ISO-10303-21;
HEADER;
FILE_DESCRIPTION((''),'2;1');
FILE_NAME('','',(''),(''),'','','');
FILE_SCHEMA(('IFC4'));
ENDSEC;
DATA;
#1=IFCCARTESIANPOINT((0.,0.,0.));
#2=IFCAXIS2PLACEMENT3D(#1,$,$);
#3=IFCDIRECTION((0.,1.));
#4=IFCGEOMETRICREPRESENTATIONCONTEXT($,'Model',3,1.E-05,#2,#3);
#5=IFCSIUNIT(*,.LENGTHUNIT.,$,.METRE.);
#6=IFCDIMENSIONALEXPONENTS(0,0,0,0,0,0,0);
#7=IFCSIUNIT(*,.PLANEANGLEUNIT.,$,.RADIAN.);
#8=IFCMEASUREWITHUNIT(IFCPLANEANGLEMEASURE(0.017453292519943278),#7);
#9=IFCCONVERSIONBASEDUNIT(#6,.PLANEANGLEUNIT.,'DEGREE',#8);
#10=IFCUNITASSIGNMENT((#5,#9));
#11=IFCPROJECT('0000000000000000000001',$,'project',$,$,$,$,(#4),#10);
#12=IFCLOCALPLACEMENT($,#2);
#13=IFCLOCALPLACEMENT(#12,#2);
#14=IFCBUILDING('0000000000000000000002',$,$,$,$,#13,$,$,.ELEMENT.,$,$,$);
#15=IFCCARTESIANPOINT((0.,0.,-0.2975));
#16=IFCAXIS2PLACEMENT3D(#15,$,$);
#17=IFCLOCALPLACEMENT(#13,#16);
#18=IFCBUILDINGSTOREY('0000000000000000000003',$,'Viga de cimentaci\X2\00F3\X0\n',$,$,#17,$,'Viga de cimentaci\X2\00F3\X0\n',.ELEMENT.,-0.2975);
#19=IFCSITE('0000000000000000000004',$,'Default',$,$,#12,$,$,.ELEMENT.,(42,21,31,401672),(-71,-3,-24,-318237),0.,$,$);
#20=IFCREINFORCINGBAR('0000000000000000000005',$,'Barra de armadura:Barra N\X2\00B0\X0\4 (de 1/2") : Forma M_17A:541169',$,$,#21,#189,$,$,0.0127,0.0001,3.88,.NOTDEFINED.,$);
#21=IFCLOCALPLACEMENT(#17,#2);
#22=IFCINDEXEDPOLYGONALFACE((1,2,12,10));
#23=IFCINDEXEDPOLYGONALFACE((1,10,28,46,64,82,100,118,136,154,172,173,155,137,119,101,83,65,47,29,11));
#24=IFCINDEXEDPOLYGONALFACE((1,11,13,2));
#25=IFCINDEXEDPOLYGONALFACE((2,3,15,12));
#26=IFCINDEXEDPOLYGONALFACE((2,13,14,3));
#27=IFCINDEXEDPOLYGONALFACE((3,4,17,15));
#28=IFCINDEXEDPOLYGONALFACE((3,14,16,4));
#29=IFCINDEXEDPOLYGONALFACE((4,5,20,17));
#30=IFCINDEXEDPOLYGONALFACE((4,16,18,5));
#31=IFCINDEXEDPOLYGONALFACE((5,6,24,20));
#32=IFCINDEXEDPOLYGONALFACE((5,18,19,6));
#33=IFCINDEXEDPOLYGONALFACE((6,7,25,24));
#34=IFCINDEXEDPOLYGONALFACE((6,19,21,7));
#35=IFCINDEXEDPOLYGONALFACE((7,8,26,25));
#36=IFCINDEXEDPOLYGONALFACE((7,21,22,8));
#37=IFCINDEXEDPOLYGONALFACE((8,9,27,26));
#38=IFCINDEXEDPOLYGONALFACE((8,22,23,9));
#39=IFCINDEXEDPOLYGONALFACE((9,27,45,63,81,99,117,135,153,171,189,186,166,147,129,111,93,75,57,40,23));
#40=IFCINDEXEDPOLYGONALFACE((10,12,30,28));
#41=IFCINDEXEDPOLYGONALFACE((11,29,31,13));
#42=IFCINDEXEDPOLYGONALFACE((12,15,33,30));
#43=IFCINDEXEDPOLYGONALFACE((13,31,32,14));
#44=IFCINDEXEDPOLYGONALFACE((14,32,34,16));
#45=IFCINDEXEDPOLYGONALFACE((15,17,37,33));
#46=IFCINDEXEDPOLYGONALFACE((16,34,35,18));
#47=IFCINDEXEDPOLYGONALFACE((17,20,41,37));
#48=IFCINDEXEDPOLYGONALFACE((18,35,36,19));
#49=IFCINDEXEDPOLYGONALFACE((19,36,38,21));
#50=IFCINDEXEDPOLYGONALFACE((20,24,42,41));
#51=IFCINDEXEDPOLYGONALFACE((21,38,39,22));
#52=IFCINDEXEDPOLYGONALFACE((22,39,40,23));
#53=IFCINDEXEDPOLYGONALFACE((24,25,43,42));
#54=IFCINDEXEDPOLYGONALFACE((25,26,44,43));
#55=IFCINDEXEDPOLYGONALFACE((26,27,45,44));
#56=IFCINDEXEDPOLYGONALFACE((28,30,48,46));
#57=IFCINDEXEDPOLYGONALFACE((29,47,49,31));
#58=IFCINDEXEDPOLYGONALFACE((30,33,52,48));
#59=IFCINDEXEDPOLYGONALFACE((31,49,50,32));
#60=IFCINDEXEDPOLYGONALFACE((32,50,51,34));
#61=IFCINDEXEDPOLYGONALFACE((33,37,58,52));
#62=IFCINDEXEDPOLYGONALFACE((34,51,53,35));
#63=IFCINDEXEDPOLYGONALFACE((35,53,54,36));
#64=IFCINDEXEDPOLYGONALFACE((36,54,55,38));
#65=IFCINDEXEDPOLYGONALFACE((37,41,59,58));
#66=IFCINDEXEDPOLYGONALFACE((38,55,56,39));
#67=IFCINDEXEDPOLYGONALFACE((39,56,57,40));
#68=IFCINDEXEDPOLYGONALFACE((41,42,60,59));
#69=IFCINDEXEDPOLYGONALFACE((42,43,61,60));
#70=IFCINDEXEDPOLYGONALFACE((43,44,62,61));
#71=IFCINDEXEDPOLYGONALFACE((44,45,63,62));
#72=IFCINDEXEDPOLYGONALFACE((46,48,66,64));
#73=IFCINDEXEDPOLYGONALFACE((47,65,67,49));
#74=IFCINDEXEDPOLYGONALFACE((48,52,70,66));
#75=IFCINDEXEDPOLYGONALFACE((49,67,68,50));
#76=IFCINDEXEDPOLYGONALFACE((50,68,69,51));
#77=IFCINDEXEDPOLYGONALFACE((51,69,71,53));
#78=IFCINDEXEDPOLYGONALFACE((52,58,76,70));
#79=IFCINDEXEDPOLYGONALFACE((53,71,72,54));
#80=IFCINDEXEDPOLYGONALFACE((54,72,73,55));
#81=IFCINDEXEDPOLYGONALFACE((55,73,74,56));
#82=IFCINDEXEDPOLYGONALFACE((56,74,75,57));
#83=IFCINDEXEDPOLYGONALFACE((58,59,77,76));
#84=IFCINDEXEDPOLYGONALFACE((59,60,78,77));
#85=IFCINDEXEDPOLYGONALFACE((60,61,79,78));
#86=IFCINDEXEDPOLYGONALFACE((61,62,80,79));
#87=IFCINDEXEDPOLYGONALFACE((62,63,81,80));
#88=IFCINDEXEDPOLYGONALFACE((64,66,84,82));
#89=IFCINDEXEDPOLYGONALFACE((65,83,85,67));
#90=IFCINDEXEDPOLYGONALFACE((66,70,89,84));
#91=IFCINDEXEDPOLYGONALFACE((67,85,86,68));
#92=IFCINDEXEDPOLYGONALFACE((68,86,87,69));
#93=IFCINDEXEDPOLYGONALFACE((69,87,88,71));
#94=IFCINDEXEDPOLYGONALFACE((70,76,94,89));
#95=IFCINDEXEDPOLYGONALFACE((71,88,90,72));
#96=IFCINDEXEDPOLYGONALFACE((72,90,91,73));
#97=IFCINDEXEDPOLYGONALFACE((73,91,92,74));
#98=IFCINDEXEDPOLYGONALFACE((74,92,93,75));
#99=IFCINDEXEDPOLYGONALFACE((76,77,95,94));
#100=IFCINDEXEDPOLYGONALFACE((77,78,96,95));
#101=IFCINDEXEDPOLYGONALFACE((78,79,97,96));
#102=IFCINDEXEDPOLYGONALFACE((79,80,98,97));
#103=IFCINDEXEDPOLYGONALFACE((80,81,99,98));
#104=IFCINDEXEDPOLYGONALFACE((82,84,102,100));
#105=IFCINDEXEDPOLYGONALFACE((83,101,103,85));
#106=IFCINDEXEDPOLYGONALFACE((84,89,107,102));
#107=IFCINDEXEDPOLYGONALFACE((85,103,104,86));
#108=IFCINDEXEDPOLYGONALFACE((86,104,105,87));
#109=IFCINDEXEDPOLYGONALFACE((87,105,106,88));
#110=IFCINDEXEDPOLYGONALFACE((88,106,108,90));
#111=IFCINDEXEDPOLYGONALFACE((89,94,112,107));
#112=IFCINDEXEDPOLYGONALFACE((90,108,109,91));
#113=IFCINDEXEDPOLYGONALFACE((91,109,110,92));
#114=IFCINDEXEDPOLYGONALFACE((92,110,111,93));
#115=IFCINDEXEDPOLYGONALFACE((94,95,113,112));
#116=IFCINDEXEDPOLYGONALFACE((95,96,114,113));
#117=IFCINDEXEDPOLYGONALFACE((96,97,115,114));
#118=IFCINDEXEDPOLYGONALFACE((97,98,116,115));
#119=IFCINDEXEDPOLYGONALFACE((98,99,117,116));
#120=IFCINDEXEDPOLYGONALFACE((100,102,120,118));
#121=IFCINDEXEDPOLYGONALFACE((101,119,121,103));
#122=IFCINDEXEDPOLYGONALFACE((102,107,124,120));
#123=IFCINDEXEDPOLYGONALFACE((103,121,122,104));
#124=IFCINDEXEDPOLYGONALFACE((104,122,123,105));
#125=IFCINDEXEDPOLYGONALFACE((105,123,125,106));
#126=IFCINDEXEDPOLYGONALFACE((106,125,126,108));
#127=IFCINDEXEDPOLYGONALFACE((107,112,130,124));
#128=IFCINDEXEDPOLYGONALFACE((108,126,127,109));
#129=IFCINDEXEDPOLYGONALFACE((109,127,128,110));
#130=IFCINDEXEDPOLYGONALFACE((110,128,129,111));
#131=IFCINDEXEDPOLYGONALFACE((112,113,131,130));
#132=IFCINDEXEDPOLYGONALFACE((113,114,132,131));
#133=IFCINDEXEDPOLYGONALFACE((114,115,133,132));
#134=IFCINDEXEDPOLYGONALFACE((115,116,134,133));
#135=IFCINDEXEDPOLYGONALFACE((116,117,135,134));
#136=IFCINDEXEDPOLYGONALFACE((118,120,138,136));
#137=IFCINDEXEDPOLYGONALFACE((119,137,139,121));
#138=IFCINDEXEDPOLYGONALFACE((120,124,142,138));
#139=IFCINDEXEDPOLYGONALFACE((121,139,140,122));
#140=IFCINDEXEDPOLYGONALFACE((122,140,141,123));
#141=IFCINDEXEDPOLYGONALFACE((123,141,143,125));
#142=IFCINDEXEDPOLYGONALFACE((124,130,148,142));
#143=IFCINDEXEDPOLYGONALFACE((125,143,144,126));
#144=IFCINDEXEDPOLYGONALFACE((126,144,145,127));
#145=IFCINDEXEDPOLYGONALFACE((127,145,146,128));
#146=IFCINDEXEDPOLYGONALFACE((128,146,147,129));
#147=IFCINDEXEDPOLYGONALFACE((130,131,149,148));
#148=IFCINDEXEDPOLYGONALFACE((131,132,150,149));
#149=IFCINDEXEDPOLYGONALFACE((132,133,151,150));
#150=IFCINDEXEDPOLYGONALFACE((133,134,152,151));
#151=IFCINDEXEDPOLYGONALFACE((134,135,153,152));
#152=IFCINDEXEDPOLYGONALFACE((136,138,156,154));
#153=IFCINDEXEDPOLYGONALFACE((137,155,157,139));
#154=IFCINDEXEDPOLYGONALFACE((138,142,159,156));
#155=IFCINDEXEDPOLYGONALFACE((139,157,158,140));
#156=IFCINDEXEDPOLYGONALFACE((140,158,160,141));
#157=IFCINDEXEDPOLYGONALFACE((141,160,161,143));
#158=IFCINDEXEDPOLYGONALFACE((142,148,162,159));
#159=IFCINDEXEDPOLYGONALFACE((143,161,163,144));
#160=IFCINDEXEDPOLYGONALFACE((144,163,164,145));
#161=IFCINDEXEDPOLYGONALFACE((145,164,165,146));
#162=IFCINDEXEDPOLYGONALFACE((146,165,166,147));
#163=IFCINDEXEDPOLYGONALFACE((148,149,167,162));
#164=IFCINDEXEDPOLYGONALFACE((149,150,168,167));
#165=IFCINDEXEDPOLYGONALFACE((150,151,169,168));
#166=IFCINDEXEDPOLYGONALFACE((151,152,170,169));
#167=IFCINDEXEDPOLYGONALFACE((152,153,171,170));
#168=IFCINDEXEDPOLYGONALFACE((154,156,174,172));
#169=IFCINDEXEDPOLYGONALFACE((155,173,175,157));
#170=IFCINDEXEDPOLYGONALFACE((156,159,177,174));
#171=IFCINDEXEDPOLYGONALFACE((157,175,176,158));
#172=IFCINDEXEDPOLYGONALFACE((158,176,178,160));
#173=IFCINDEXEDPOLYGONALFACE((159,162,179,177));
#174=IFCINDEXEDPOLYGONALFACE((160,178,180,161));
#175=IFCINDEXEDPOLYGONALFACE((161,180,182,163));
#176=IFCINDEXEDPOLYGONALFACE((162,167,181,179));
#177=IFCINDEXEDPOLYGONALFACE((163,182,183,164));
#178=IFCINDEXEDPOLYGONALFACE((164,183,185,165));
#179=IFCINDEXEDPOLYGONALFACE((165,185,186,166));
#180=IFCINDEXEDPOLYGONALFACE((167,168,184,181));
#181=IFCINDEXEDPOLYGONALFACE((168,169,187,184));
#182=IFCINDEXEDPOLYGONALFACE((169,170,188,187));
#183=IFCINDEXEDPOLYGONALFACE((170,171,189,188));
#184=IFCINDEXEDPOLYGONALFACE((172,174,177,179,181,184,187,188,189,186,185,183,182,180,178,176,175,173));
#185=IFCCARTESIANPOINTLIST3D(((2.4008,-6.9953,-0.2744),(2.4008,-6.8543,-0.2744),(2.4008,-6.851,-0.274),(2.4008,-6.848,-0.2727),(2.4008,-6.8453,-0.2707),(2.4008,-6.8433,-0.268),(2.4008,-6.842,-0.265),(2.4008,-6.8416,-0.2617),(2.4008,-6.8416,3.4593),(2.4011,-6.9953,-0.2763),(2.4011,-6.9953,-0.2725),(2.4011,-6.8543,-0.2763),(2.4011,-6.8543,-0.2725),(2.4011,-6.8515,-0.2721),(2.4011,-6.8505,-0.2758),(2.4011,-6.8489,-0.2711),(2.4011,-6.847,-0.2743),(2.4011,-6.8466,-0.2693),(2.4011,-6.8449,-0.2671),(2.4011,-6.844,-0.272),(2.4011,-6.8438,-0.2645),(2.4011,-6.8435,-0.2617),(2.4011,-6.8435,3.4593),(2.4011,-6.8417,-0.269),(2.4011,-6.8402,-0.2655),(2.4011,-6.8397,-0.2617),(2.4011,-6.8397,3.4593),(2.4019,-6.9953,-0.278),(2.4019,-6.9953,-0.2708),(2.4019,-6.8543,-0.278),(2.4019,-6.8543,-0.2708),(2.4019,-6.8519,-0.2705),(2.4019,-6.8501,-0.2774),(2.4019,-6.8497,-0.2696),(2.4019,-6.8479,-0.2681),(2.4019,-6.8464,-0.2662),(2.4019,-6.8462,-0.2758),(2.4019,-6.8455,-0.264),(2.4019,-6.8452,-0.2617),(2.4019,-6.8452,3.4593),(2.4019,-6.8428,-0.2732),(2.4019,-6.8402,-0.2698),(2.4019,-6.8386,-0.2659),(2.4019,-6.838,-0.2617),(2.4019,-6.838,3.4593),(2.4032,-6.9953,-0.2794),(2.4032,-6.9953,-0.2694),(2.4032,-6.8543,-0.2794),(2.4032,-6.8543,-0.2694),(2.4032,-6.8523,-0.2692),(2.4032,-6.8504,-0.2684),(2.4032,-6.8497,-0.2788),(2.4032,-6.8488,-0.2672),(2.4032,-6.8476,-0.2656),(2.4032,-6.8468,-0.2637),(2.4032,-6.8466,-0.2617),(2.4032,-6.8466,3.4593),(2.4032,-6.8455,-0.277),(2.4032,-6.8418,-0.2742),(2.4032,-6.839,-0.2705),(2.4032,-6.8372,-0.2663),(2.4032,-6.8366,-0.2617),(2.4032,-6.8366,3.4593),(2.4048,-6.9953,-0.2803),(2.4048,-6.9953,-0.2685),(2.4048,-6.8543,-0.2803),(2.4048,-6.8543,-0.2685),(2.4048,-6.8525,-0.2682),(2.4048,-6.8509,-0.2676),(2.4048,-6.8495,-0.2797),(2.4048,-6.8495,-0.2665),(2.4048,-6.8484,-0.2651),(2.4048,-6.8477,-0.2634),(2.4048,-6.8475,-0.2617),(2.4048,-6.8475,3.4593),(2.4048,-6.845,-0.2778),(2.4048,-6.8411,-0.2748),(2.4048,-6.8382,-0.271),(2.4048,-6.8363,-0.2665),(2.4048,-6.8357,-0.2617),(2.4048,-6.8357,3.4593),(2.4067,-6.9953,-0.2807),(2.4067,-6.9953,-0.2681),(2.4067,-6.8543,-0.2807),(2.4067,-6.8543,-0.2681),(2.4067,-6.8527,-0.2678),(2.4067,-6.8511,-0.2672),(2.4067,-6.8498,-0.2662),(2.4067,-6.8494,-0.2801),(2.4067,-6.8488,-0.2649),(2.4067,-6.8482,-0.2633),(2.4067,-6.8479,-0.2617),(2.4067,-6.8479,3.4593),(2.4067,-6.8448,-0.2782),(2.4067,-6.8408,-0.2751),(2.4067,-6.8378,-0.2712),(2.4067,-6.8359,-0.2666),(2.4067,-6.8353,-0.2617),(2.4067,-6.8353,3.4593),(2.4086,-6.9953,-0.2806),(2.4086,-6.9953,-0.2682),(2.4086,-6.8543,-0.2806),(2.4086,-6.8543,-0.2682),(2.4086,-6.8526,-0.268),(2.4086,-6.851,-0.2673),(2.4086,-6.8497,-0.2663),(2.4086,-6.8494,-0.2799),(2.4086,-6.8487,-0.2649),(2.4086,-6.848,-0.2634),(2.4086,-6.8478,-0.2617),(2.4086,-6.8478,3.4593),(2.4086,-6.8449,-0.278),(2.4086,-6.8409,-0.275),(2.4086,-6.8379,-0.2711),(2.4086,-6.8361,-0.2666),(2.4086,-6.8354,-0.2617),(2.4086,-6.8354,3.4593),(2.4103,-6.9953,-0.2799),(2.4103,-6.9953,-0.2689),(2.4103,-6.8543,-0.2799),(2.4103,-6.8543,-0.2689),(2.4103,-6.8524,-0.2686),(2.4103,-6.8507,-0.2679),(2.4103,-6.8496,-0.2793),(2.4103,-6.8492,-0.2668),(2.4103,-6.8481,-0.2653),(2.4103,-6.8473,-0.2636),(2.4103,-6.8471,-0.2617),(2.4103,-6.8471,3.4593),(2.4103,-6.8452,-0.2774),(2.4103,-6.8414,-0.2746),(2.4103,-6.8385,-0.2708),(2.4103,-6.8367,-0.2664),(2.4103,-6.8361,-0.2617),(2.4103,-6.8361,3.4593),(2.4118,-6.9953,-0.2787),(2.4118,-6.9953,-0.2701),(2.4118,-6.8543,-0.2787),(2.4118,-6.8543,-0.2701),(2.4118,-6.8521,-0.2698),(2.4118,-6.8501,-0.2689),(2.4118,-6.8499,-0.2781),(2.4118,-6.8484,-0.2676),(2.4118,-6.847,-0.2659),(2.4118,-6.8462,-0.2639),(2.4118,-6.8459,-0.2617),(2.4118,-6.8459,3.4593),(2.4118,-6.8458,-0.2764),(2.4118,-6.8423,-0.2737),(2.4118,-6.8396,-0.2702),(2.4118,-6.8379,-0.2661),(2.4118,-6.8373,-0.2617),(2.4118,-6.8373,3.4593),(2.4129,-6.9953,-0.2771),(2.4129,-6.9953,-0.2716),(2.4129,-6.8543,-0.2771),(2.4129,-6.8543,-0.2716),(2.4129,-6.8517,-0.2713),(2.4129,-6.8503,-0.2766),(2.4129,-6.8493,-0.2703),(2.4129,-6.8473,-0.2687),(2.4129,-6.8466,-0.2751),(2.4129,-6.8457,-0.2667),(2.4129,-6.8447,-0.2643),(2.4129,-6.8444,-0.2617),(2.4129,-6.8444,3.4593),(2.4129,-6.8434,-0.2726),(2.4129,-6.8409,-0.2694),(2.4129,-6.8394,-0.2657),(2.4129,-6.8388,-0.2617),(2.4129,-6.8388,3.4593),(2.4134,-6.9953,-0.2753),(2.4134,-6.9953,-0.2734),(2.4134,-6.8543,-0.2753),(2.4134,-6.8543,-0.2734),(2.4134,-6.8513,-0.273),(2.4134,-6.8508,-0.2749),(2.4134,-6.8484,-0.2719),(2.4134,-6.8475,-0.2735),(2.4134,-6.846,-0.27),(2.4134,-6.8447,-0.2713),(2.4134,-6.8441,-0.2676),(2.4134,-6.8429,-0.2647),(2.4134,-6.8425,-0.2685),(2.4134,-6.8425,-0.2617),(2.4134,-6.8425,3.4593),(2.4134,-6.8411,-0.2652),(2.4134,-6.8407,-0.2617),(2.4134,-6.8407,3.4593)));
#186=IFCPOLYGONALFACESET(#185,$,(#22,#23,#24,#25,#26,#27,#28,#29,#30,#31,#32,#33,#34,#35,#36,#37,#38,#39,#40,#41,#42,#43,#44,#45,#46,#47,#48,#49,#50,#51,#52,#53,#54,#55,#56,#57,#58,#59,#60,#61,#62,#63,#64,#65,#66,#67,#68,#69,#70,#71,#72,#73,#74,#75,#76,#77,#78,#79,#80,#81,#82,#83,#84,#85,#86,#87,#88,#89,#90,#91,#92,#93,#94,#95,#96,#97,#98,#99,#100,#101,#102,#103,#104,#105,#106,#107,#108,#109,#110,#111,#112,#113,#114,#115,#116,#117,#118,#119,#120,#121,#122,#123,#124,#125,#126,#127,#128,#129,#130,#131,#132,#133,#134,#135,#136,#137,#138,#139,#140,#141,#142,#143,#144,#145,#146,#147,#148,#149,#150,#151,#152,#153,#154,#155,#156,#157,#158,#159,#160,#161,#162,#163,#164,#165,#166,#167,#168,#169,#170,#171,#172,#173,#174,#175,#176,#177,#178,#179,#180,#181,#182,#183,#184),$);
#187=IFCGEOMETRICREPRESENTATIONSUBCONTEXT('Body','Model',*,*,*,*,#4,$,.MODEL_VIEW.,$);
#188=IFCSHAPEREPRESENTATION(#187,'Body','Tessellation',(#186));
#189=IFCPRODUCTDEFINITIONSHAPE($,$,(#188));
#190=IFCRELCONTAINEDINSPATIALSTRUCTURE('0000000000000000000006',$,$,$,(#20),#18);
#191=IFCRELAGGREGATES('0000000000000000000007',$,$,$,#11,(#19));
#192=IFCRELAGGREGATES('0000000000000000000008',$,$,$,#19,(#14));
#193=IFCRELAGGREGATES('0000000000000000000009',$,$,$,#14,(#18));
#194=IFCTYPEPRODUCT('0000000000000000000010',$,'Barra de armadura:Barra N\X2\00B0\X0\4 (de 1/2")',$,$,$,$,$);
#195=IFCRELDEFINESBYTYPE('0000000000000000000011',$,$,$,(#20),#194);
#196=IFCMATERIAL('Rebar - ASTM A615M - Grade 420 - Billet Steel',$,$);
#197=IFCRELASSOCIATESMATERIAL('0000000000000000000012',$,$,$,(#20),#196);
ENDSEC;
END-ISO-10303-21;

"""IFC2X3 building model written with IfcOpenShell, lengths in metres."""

from ifc_helpers import new_model, entity, si_unit, converted_unit, direction, frame, origin, place, context, subcontext, project, spatial, material, type_object, element, save


model = new_model("IFC2X3")

# Units and contexts
model_context = context("Model", 3, precision=1e-05, world=origin(), true_north=direction((0.0, 1.0)))
body_context = subcontext(model_context, "Body", "Model", "MODEL_VIEW")
ifc_project = project(units=[si_unit("LENGTHUNIT", "METRE"), converted_unit("PLANEANGLEUNIT", "DEGREE", entity("IfcPlaneAngleMeasure", 0.017453292519943278), si_unit("PLANEANGLEUNIT", "RADIAN"), dimensions=[0, 0, 0, 0, 0, 0, 0])], contexts=[model_context])

# Site, building, storey
site_placement = place(None, origin())
site = spatial("IfcSite", under=ifc_project, at=site_placement, Name="Default", CompositionType="ELEMENT", RefLatitude=(42, 21, 31, 401672), RefLongitude=(-71, -3, -24, -318237), RefElevation=0.0)
building_placement = place(site_placement, origin())
building = spatial("IfcBuilding", under=site, at=building_placement, CompositionType="ELEMENT")
storey_placement = place(building_placement, frame((0.0, 0.0, -0.2975)))
storey = spatial("IfcBuildingStorey", under=building, at=storey_placement, Name="Viga de cimentación", LongName="Viga de cimentación", CompositionType="ELEMENT", Elevation=-0.2975)

# Reinforcing bar
ifc_material_1 = material(Name="Rebar - ASTM A615M - Grade 420 - Billet Steel")
type_product_1 = type_object("IfcTypeProduct", Name="Barra de armadura:Barra N°4 (de 1/2\")")
reinforcing_bar_1_placement = place(storey_placement, origin())
element("IfcReinforcingBar", 1, at=reinforcing_bar_1_placement, inside=storey, type_object=type_product_1, material=ifc_material_1, Name="Barra de armadura:Barra N°4 (de 1/2\") : Forma M_17A:541169", BarLength=3.88, BarRole="NOTDEFINED", CrossSectionArea=0.0001, NominalDiameter=0.0127, context=body_context, shape_type="AdvancedSweptSolid", body=[
    entity("IfcSweptDiskSolid", entity("IfcCompositeCurve", [entity("IfcCompositeCurveSegment", "CONTINUOUS", True, entity("IfcPolyline", [entity("IfcCartesianPoint", [2.4071, -6.8416, 3.4593]), entity("IfcCartesianPoint", [2.4071, -6.8416, -0.2617])])), entity("IfcCompositeCurveSegment", "CONTINUOUS", True, entity("IfcTrimmedCurve", entity("IfcCircle", entity("IfcAxis2Placement3D", entity("IfcCartesianPoint", [2.4071, -6.8543, -0.2617]), entity("IfcDirection", [-1.0, 0.0, 0.0]), entity("IfcDirection", [0.0, 0.0, -1.0])), 0.0127), [entity("IfcParameterValue", 270.0)], [entity("IfcParameterValue", 360.0)], True, "PARAMETER")), entity("IfcCompositeCurveSegment", "CONTINUOUS", True, entity("IfcPolyline", [entity("IfcCartesianPoint", [2.4071, -6.8543, -0.2744]), entity("IfcCartesianPoint", [2.4071, -6.9953, -0.2744])]))], False), 0.0063, None, 0.0, 92.0),
])

save(model, "model.ifc")
